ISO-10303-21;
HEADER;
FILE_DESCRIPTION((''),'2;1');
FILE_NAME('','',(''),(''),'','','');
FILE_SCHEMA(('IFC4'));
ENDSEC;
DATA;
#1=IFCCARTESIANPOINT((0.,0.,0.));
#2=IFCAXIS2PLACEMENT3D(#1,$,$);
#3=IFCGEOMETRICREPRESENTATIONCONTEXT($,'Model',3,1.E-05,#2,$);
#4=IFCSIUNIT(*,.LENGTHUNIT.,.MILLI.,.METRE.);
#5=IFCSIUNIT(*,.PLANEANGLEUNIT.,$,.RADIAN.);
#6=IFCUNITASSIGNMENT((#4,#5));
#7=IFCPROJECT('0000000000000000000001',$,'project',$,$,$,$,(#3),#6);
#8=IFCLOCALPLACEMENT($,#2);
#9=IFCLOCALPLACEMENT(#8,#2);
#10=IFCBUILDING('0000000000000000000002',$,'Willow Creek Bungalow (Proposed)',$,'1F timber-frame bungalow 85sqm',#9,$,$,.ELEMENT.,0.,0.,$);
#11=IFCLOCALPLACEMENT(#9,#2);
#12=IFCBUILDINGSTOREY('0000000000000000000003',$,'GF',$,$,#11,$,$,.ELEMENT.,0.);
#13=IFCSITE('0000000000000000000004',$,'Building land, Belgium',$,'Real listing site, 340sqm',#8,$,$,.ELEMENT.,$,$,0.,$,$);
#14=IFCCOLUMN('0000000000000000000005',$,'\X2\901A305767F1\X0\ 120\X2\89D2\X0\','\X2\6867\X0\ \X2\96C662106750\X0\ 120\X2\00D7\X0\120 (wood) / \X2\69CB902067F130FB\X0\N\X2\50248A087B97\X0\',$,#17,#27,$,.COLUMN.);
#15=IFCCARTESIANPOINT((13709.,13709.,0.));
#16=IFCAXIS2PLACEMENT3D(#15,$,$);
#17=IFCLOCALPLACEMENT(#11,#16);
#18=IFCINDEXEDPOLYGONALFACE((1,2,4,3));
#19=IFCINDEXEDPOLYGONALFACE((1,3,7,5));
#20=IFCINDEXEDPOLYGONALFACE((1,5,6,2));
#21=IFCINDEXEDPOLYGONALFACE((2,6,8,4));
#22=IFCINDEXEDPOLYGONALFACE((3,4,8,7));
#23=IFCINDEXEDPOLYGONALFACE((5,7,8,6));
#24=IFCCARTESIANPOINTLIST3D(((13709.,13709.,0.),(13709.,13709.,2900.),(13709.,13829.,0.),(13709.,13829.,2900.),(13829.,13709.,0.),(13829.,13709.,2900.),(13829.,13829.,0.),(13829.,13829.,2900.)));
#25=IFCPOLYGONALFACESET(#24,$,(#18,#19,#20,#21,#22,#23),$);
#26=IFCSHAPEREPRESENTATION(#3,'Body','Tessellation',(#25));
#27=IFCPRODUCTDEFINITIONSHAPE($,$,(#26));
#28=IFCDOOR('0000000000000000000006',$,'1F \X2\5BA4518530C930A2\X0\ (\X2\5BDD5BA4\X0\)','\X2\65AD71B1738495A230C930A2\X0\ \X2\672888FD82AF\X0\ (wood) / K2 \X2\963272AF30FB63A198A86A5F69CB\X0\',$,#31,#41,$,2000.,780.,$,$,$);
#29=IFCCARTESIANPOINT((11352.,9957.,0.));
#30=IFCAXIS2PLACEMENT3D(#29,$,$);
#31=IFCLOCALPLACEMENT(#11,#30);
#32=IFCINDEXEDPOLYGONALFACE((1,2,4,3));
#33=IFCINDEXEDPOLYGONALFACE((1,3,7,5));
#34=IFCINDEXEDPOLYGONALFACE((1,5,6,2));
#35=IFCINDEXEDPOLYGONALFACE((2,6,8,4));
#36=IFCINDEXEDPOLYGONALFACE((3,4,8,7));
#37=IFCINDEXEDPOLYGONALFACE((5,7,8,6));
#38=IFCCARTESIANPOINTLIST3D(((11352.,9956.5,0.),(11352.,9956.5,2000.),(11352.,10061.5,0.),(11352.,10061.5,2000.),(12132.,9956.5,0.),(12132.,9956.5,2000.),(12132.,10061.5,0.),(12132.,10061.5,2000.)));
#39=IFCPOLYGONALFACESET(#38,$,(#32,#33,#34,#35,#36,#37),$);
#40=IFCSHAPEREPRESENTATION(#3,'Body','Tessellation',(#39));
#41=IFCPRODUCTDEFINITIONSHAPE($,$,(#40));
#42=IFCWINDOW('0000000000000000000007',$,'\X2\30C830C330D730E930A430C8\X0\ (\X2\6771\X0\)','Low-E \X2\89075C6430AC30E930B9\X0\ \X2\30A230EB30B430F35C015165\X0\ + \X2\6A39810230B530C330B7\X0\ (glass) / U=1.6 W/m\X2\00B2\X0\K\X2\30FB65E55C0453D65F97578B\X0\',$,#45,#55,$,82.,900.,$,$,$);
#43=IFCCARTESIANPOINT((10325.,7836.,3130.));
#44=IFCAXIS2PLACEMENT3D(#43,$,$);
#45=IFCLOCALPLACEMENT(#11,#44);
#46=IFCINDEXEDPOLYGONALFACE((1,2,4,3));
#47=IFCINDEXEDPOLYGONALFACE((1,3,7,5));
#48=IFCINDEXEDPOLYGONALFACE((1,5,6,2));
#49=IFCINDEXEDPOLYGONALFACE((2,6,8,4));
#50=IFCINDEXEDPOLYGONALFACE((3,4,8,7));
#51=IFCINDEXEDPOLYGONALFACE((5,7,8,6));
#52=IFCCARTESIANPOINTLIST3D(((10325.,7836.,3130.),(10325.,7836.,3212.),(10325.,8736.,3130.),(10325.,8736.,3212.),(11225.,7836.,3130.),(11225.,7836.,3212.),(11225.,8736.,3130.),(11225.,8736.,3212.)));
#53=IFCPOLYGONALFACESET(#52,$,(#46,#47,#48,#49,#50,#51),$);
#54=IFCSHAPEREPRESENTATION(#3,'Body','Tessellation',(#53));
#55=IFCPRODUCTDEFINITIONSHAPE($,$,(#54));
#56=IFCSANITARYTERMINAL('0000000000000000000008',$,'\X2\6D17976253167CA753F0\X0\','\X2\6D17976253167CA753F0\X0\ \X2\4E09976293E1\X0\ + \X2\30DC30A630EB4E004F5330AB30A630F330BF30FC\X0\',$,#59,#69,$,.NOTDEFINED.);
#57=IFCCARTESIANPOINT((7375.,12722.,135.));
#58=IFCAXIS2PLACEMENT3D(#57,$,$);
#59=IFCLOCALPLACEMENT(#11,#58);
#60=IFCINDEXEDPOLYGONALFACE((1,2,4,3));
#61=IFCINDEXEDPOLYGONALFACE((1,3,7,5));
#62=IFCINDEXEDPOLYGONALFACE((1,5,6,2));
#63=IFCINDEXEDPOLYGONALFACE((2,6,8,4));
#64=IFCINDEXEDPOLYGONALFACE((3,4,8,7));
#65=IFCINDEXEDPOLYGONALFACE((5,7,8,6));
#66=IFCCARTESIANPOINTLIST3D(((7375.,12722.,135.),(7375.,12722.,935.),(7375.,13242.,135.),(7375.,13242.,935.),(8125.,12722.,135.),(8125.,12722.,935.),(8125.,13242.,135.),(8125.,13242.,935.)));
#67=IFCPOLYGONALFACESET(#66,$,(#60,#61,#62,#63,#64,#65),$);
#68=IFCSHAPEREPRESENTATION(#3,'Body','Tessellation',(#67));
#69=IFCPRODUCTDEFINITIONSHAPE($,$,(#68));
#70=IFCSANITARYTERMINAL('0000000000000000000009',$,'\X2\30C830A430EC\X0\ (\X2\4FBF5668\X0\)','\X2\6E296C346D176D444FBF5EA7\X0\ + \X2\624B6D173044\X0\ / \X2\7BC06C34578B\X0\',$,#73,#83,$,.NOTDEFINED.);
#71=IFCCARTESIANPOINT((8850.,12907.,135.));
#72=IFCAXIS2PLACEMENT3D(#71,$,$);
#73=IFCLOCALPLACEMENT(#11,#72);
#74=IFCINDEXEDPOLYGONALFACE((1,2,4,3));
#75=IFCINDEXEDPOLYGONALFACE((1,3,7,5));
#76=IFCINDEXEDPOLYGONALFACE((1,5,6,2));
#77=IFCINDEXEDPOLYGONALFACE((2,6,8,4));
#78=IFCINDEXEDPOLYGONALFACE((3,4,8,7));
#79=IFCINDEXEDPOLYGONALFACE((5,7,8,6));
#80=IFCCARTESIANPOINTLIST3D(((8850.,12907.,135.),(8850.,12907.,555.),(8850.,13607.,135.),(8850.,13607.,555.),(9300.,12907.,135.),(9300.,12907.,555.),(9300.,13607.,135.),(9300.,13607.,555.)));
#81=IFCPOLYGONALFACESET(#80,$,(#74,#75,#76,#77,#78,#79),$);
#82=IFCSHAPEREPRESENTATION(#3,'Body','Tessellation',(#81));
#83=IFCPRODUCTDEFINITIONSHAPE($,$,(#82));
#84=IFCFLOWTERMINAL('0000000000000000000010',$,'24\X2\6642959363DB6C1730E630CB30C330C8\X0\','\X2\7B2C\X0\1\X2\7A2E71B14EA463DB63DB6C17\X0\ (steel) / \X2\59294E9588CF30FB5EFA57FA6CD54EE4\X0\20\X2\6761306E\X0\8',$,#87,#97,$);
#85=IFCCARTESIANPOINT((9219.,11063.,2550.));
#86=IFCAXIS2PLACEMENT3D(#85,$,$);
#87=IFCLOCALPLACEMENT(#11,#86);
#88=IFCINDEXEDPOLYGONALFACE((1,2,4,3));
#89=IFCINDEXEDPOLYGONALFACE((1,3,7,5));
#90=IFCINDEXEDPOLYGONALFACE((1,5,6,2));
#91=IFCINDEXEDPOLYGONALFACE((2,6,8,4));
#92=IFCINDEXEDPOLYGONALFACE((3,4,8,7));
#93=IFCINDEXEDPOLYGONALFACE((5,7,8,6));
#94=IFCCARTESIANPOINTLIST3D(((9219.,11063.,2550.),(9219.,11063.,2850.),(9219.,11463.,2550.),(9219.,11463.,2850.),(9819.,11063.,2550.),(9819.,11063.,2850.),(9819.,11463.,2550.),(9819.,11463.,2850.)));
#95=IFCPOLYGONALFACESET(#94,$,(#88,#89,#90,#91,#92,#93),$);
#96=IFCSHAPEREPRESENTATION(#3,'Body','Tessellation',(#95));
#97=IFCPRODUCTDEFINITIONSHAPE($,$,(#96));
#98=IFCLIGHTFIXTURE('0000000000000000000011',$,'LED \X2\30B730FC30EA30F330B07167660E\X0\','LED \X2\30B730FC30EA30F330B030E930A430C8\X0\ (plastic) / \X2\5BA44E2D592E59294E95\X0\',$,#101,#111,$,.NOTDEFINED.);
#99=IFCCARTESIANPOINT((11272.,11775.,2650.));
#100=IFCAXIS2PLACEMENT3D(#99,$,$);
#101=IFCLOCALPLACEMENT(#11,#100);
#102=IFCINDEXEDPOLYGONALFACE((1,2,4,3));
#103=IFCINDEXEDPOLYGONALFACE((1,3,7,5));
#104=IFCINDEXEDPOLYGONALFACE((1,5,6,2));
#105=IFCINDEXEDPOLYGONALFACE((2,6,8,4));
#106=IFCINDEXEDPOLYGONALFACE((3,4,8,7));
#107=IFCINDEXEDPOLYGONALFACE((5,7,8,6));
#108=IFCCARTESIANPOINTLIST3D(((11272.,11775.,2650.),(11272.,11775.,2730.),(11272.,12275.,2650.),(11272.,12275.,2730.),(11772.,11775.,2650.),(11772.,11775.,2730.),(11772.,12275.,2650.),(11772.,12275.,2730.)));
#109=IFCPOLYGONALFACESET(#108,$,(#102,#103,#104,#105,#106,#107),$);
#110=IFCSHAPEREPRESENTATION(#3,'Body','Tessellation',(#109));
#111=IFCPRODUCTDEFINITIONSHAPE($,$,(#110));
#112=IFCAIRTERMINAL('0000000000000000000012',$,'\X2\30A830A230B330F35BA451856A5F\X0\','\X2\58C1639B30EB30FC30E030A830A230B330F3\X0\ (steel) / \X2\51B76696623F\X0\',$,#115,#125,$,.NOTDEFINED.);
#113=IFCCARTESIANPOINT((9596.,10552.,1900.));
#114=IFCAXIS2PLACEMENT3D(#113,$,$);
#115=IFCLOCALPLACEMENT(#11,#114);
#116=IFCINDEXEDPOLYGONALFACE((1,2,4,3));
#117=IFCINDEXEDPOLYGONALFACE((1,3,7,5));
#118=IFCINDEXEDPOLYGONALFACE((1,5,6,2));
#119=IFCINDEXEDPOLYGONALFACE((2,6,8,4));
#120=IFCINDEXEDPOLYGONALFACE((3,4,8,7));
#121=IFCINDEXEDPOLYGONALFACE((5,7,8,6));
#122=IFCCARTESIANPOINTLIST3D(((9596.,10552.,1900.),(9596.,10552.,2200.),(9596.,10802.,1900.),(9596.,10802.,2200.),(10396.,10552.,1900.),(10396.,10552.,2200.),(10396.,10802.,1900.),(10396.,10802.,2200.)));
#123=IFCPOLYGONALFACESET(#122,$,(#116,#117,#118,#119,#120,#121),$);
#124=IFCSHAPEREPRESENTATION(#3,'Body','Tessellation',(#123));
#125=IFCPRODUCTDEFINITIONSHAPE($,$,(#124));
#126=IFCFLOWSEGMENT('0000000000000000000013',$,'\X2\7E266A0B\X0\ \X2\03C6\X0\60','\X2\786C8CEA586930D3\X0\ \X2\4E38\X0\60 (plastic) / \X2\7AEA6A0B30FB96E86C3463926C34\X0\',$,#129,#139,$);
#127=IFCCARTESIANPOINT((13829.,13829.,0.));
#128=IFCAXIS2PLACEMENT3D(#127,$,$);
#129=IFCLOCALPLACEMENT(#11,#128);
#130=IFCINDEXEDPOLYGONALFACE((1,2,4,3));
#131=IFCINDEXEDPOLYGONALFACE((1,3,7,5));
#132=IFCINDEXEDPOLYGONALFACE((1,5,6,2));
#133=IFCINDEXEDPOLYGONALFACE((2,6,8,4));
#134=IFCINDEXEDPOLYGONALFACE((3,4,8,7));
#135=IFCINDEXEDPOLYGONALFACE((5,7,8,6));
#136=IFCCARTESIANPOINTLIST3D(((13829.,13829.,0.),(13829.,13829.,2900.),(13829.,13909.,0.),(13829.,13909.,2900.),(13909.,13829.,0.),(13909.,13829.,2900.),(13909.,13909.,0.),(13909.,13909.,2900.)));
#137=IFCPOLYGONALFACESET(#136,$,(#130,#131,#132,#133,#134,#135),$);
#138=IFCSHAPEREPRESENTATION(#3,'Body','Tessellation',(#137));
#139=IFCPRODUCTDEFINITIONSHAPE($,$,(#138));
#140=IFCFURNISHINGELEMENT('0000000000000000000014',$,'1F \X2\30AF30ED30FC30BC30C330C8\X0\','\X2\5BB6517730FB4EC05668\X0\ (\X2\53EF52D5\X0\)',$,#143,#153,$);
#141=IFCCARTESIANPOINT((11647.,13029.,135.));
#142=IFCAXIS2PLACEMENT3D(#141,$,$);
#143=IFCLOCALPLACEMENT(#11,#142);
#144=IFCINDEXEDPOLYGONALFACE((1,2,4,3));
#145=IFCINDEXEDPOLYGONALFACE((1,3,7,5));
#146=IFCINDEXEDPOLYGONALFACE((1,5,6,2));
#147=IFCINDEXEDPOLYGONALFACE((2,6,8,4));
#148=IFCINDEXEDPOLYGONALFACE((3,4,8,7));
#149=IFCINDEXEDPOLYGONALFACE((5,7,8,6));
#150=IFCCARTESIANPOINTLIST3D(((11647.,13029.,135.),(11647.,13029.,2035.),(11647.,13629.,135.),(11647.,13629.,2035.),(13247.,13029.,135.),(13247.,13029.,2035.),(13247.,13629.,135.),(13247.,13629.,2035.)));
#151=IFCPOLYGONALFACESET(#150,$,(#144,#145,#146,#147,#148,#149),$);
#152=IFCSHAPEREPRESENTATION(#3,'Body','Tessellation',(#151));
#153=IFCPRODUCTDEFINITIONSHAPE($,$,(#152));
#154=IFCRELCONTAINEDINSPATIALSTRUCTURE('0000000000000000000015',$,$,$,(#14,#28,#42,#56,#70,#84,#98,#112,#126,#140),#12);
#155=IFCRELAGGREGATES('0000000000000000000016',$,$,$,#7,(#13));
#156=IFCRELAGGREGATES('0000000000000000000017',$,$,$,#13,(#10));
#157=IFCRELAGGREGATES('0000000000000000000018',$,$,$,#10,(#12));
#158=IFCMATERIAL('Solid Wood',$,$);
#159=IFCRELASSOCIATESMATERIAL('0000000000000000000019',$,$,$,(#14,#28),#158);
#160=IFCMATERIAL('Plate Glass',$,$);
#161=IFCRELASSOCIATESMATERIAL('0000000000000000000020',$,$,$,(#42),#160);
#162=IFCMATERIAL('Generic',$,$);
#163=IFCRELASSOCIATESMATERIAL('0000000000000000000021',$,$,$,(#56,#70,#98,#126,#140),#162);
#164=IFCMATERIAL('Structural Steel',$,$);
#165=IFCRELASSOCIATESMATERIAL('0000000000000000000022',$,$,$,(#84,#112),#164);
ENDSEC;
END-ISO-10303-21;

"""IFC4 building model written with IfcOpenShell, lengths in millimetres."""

from ifc_helpers import new_model, si_unit, frame, frame_2d, origin, place, context, project, spatial, rectangle, extrude, material, element, save


model = new_model("IFC4")

# Units and contexts
model_context = context("Model", 3, precision=1e-05, world=origin())
ifc_project = project(units=[si_unit("LENGTHUNIT", "METRE", prefix="MILLI"), si_unit("PLANEANGLEUNIT", "RADIAN")], contexts=[model_context])

# Site, building, storey
site_placement = place(None, origin())
site = spatial("IfcSite", under=ifc_project, at=site_placement, Name="Building land, Belgium", ObjectType="Real listing site, 340sqm", CompositionType="ELEMENT", RefElevation=0.0)
building_placement = place(site_placement, origin())
building = spatial("IfcBuilding", under=site, at=building_placement, Name="Willow Creek Bungalow (Proposed)", ObjectType="1F timber-frame bungalow 85sqm", CompositionType="ELEMENT", ElevationOfRefHeight=0.0, ElevationOfTerrain=0.0)
storey_placement = place(building_placement, origin())
storey = spatial("IfcBuildingStorey", under=building, at=storey_placement, Name="GF", CompositionType="ELEMENT", Elevation=0.0)

# Column
ifc_material_1 = material(Name="Solid Wood")
column_1_placement = place(storey_placement, frame((13709.0, 13709.0, 0.0)))
element("IfcColumn", 1, at=column_1_placement, inside=storey, material=ifc_material_1, Name="通し柱 120角", Description="桧 集成材 120×120 (wood) / 構造柱・N値計算", PredefinedType="COLUMN", context=model_context, shape_type="SweptSolid", body=[
    extrude(rectangle(XDim=120.0, YDim=120.0, at=frame_2d((60.0, 60.0))), frame((13709.0, 13709.0, 0.0)), (0.0, 0.0, 1.0), 2900.0),
])

# Door
door_placement = place(storey_placement, frame((11352.0, 9957.0, 0.0)))
element("IfcDoor", 2, at=door_placement, inside=storey, material=ifc_material_1, Name="1F 室内ドア (寝室)", Description="断熱玄関ドア 木製芯 (wood) / K2 防犯・採風機構", OverallHeight=2000.0, OverallWidth=780.0, context=model_context, shape_type="SweptSolid", body=[
    extrude(rectangle(XDim=780.0, YDim=105.0, at=frame_2d((390.0, 52.0))), frame((11352.0, 9957.0, 0.0)), (0.0, 0.0, 1.0), 2000.0),
])

# Window
ifc_material_2 = material(Name="Plate Glass")
window_placement = place(storey_placement, frame((10325.0, 7836.0, 3130.0)))
element("IfcWindow", 3, at=window_placement, inside=storey, material=ifc_material_2, Name="トップライト (東)", Description="Low-E 複層ガラス アルゴン封入 + 樹脂サッシ (glass) / U=1.6 W/m²K・日射取得型", OverallHeight=82.0, OverallWidth=900.0, context=model_context, shape_type="SweptSolid", body=[
    extrude(rectangle(XDim=900.0, YDim=900.0, at=frame_2d((450.0, 450.0))), frame((10325.0, 7836.0, 3130.0)), (0.0, 0.0, 1.0), 82.0),
])

# Sanitary terminals
ifc_material_3 = material(Name="Generic")
sanitary_terminal_1_placement = place(storey_placement, frame((7375.0, 12722.0, 135.0)))
element("IfcSanitaryTerminal", 4, at=sanitary_terminal_1_placement, inside=storey, material=ifc_material_3, Name="洗面化粧台", Description="洗面化粧台 三面鏡 + ボウル一体カウンター", PredefinedType="NOTDEFINED", context=model_context, shape_type="SweptSolid", body=[
    extrude(rectangle(XDim=750.0, YDim=520.0, at=frame_2d((375.0, 260.0))), frame((7375.0, 12722.0, 135.0)), (0.0, 0.0, 1.0), 800.0),
])
sanitary_terminal_2_placement = place(storey_placement, frame((8850.0, 12907.0, 135.0)))
element("IfcSanitaryTerminal", 5, at=sanitary_terminal_2_placement, inside=storey, material=ifc_material_3, Name="トイレ (便器)", Description="温水洗浄便座 + 手洗い / 節水型", PredefinedType="NOTDEFINED", context=model_context, shape_type="SweptSolid", body=[
    extrude(rectangle(XDim=450.0, YDim=700.0, at=frame_2d((225.0, 350.0))), frame((8850.0, 12907.0, 135.0)), (0.0, 0.0, 1.0), 420.0),
])

# Flow terminal
ifc_material_4 = material(Name="Structural Steel")
flow_terminal_placement = place(storey_placement, frame((9219.0, 11063.0, 2550.0)))
element("IfcFlowTerminal", 6, at=flow_terminal_placement, inside=storey, material=ifc_material_4, Name="24時間換気ユニット", Description="第1種熱交換換気 (steel) / 天井裏・建基法令20条の8", context=model_context, shape_type="SweptSolid", body=[
    extrude(rectangle(XDim=600.0, YDim=400.0, at=frame_2d((300.0, 200.0))), frame((9219.0, 11063.0, 2550.0)), (0.0, 0.0, 1.0), 300.0),
])

# Light fixture
light_fixture_placement = place(storey_placement, frame((11272.0, 11775.0, 2650.0)))
element("IfcLightFixture", 7, at=light_fixture_placement, inside=storey, material=ifc_material_3, Name="LED シーリング照明", Description="LED シーリングライト (plastic) / 室中央天井", PredefinedType="NOTDEFINED", context=model_context, shape_type="SweptSolid", body=[
    extrude(rectangle(XDim=500.0, YDim=500.0, at=frame_2d((250.0, 250.0))), frame((11272.0, 11775.0, 2650.0)), (0.0, 0.0, 1.0), 80.0),
])

# Air terminal
air_terminal_placement = place(storey_placement, frame((9596.0, 10552.0, 1900.0)))
element("IfcAirTerminal", 8, at=air_terminal_placement, inside=storey, material=ifc_material_4, Name="エアコン室内機", Description="壁掛ルームエアコン (steel) / 冷暖房", PredefinedType="NOTDEFINED", context=model_context, shape_type="SweptSolid", body=[
    extrude(rectangle(XDim=800.0, YDim=250.0, at=frame_2d((400.0, 125.0))), frame((9596.0, 10552.0, 1900.0)), (0.0, 0.0, 1.0), 300.0),
])

# Flow segment
flow_segment_placement = place(storey_placement, frame((13829.0, 13829.0, 0.0)))
element("IfcFlowSegment", 9, at=flow_segment_placement, inside=storey, material=ifc_material_3, Name="縦樋 φ60", Description="硬質塩ビ 丸60 (plastic) / 竪樋・雨水排水", context=model_context, shape_type="SweptSolid", body=[
    extrude(rectangle(XDim=80.0, YDim=80.0, at=frame_2d((40.0, 40.0))), frame((13829.0, 13829.0, 0.0)), (0.0, 0.0, 1.0), 2900.0),
])

# Furnishing element
furnishing_placement = place(storey_placement, frame((11647.0, 13029.0, 135.0)))
element("IfcFurnishingElement", 10, at=furnishing_placement, inside=storey, material=ifc_material_3, Name="1F クローゼット", Description="家具・什器 (可動)", context=model_context, shape_type="SweptSolid", body=[
    extrude(rectangle(XDim=1600.0, YDim=600.0, at=frame_2d((800.0, 300.0))), frame((11647.0, 13029.0, 135.0)), (0.0, 0.0, 1.0), 1900.0),
])

save(model, "model.ifc")
